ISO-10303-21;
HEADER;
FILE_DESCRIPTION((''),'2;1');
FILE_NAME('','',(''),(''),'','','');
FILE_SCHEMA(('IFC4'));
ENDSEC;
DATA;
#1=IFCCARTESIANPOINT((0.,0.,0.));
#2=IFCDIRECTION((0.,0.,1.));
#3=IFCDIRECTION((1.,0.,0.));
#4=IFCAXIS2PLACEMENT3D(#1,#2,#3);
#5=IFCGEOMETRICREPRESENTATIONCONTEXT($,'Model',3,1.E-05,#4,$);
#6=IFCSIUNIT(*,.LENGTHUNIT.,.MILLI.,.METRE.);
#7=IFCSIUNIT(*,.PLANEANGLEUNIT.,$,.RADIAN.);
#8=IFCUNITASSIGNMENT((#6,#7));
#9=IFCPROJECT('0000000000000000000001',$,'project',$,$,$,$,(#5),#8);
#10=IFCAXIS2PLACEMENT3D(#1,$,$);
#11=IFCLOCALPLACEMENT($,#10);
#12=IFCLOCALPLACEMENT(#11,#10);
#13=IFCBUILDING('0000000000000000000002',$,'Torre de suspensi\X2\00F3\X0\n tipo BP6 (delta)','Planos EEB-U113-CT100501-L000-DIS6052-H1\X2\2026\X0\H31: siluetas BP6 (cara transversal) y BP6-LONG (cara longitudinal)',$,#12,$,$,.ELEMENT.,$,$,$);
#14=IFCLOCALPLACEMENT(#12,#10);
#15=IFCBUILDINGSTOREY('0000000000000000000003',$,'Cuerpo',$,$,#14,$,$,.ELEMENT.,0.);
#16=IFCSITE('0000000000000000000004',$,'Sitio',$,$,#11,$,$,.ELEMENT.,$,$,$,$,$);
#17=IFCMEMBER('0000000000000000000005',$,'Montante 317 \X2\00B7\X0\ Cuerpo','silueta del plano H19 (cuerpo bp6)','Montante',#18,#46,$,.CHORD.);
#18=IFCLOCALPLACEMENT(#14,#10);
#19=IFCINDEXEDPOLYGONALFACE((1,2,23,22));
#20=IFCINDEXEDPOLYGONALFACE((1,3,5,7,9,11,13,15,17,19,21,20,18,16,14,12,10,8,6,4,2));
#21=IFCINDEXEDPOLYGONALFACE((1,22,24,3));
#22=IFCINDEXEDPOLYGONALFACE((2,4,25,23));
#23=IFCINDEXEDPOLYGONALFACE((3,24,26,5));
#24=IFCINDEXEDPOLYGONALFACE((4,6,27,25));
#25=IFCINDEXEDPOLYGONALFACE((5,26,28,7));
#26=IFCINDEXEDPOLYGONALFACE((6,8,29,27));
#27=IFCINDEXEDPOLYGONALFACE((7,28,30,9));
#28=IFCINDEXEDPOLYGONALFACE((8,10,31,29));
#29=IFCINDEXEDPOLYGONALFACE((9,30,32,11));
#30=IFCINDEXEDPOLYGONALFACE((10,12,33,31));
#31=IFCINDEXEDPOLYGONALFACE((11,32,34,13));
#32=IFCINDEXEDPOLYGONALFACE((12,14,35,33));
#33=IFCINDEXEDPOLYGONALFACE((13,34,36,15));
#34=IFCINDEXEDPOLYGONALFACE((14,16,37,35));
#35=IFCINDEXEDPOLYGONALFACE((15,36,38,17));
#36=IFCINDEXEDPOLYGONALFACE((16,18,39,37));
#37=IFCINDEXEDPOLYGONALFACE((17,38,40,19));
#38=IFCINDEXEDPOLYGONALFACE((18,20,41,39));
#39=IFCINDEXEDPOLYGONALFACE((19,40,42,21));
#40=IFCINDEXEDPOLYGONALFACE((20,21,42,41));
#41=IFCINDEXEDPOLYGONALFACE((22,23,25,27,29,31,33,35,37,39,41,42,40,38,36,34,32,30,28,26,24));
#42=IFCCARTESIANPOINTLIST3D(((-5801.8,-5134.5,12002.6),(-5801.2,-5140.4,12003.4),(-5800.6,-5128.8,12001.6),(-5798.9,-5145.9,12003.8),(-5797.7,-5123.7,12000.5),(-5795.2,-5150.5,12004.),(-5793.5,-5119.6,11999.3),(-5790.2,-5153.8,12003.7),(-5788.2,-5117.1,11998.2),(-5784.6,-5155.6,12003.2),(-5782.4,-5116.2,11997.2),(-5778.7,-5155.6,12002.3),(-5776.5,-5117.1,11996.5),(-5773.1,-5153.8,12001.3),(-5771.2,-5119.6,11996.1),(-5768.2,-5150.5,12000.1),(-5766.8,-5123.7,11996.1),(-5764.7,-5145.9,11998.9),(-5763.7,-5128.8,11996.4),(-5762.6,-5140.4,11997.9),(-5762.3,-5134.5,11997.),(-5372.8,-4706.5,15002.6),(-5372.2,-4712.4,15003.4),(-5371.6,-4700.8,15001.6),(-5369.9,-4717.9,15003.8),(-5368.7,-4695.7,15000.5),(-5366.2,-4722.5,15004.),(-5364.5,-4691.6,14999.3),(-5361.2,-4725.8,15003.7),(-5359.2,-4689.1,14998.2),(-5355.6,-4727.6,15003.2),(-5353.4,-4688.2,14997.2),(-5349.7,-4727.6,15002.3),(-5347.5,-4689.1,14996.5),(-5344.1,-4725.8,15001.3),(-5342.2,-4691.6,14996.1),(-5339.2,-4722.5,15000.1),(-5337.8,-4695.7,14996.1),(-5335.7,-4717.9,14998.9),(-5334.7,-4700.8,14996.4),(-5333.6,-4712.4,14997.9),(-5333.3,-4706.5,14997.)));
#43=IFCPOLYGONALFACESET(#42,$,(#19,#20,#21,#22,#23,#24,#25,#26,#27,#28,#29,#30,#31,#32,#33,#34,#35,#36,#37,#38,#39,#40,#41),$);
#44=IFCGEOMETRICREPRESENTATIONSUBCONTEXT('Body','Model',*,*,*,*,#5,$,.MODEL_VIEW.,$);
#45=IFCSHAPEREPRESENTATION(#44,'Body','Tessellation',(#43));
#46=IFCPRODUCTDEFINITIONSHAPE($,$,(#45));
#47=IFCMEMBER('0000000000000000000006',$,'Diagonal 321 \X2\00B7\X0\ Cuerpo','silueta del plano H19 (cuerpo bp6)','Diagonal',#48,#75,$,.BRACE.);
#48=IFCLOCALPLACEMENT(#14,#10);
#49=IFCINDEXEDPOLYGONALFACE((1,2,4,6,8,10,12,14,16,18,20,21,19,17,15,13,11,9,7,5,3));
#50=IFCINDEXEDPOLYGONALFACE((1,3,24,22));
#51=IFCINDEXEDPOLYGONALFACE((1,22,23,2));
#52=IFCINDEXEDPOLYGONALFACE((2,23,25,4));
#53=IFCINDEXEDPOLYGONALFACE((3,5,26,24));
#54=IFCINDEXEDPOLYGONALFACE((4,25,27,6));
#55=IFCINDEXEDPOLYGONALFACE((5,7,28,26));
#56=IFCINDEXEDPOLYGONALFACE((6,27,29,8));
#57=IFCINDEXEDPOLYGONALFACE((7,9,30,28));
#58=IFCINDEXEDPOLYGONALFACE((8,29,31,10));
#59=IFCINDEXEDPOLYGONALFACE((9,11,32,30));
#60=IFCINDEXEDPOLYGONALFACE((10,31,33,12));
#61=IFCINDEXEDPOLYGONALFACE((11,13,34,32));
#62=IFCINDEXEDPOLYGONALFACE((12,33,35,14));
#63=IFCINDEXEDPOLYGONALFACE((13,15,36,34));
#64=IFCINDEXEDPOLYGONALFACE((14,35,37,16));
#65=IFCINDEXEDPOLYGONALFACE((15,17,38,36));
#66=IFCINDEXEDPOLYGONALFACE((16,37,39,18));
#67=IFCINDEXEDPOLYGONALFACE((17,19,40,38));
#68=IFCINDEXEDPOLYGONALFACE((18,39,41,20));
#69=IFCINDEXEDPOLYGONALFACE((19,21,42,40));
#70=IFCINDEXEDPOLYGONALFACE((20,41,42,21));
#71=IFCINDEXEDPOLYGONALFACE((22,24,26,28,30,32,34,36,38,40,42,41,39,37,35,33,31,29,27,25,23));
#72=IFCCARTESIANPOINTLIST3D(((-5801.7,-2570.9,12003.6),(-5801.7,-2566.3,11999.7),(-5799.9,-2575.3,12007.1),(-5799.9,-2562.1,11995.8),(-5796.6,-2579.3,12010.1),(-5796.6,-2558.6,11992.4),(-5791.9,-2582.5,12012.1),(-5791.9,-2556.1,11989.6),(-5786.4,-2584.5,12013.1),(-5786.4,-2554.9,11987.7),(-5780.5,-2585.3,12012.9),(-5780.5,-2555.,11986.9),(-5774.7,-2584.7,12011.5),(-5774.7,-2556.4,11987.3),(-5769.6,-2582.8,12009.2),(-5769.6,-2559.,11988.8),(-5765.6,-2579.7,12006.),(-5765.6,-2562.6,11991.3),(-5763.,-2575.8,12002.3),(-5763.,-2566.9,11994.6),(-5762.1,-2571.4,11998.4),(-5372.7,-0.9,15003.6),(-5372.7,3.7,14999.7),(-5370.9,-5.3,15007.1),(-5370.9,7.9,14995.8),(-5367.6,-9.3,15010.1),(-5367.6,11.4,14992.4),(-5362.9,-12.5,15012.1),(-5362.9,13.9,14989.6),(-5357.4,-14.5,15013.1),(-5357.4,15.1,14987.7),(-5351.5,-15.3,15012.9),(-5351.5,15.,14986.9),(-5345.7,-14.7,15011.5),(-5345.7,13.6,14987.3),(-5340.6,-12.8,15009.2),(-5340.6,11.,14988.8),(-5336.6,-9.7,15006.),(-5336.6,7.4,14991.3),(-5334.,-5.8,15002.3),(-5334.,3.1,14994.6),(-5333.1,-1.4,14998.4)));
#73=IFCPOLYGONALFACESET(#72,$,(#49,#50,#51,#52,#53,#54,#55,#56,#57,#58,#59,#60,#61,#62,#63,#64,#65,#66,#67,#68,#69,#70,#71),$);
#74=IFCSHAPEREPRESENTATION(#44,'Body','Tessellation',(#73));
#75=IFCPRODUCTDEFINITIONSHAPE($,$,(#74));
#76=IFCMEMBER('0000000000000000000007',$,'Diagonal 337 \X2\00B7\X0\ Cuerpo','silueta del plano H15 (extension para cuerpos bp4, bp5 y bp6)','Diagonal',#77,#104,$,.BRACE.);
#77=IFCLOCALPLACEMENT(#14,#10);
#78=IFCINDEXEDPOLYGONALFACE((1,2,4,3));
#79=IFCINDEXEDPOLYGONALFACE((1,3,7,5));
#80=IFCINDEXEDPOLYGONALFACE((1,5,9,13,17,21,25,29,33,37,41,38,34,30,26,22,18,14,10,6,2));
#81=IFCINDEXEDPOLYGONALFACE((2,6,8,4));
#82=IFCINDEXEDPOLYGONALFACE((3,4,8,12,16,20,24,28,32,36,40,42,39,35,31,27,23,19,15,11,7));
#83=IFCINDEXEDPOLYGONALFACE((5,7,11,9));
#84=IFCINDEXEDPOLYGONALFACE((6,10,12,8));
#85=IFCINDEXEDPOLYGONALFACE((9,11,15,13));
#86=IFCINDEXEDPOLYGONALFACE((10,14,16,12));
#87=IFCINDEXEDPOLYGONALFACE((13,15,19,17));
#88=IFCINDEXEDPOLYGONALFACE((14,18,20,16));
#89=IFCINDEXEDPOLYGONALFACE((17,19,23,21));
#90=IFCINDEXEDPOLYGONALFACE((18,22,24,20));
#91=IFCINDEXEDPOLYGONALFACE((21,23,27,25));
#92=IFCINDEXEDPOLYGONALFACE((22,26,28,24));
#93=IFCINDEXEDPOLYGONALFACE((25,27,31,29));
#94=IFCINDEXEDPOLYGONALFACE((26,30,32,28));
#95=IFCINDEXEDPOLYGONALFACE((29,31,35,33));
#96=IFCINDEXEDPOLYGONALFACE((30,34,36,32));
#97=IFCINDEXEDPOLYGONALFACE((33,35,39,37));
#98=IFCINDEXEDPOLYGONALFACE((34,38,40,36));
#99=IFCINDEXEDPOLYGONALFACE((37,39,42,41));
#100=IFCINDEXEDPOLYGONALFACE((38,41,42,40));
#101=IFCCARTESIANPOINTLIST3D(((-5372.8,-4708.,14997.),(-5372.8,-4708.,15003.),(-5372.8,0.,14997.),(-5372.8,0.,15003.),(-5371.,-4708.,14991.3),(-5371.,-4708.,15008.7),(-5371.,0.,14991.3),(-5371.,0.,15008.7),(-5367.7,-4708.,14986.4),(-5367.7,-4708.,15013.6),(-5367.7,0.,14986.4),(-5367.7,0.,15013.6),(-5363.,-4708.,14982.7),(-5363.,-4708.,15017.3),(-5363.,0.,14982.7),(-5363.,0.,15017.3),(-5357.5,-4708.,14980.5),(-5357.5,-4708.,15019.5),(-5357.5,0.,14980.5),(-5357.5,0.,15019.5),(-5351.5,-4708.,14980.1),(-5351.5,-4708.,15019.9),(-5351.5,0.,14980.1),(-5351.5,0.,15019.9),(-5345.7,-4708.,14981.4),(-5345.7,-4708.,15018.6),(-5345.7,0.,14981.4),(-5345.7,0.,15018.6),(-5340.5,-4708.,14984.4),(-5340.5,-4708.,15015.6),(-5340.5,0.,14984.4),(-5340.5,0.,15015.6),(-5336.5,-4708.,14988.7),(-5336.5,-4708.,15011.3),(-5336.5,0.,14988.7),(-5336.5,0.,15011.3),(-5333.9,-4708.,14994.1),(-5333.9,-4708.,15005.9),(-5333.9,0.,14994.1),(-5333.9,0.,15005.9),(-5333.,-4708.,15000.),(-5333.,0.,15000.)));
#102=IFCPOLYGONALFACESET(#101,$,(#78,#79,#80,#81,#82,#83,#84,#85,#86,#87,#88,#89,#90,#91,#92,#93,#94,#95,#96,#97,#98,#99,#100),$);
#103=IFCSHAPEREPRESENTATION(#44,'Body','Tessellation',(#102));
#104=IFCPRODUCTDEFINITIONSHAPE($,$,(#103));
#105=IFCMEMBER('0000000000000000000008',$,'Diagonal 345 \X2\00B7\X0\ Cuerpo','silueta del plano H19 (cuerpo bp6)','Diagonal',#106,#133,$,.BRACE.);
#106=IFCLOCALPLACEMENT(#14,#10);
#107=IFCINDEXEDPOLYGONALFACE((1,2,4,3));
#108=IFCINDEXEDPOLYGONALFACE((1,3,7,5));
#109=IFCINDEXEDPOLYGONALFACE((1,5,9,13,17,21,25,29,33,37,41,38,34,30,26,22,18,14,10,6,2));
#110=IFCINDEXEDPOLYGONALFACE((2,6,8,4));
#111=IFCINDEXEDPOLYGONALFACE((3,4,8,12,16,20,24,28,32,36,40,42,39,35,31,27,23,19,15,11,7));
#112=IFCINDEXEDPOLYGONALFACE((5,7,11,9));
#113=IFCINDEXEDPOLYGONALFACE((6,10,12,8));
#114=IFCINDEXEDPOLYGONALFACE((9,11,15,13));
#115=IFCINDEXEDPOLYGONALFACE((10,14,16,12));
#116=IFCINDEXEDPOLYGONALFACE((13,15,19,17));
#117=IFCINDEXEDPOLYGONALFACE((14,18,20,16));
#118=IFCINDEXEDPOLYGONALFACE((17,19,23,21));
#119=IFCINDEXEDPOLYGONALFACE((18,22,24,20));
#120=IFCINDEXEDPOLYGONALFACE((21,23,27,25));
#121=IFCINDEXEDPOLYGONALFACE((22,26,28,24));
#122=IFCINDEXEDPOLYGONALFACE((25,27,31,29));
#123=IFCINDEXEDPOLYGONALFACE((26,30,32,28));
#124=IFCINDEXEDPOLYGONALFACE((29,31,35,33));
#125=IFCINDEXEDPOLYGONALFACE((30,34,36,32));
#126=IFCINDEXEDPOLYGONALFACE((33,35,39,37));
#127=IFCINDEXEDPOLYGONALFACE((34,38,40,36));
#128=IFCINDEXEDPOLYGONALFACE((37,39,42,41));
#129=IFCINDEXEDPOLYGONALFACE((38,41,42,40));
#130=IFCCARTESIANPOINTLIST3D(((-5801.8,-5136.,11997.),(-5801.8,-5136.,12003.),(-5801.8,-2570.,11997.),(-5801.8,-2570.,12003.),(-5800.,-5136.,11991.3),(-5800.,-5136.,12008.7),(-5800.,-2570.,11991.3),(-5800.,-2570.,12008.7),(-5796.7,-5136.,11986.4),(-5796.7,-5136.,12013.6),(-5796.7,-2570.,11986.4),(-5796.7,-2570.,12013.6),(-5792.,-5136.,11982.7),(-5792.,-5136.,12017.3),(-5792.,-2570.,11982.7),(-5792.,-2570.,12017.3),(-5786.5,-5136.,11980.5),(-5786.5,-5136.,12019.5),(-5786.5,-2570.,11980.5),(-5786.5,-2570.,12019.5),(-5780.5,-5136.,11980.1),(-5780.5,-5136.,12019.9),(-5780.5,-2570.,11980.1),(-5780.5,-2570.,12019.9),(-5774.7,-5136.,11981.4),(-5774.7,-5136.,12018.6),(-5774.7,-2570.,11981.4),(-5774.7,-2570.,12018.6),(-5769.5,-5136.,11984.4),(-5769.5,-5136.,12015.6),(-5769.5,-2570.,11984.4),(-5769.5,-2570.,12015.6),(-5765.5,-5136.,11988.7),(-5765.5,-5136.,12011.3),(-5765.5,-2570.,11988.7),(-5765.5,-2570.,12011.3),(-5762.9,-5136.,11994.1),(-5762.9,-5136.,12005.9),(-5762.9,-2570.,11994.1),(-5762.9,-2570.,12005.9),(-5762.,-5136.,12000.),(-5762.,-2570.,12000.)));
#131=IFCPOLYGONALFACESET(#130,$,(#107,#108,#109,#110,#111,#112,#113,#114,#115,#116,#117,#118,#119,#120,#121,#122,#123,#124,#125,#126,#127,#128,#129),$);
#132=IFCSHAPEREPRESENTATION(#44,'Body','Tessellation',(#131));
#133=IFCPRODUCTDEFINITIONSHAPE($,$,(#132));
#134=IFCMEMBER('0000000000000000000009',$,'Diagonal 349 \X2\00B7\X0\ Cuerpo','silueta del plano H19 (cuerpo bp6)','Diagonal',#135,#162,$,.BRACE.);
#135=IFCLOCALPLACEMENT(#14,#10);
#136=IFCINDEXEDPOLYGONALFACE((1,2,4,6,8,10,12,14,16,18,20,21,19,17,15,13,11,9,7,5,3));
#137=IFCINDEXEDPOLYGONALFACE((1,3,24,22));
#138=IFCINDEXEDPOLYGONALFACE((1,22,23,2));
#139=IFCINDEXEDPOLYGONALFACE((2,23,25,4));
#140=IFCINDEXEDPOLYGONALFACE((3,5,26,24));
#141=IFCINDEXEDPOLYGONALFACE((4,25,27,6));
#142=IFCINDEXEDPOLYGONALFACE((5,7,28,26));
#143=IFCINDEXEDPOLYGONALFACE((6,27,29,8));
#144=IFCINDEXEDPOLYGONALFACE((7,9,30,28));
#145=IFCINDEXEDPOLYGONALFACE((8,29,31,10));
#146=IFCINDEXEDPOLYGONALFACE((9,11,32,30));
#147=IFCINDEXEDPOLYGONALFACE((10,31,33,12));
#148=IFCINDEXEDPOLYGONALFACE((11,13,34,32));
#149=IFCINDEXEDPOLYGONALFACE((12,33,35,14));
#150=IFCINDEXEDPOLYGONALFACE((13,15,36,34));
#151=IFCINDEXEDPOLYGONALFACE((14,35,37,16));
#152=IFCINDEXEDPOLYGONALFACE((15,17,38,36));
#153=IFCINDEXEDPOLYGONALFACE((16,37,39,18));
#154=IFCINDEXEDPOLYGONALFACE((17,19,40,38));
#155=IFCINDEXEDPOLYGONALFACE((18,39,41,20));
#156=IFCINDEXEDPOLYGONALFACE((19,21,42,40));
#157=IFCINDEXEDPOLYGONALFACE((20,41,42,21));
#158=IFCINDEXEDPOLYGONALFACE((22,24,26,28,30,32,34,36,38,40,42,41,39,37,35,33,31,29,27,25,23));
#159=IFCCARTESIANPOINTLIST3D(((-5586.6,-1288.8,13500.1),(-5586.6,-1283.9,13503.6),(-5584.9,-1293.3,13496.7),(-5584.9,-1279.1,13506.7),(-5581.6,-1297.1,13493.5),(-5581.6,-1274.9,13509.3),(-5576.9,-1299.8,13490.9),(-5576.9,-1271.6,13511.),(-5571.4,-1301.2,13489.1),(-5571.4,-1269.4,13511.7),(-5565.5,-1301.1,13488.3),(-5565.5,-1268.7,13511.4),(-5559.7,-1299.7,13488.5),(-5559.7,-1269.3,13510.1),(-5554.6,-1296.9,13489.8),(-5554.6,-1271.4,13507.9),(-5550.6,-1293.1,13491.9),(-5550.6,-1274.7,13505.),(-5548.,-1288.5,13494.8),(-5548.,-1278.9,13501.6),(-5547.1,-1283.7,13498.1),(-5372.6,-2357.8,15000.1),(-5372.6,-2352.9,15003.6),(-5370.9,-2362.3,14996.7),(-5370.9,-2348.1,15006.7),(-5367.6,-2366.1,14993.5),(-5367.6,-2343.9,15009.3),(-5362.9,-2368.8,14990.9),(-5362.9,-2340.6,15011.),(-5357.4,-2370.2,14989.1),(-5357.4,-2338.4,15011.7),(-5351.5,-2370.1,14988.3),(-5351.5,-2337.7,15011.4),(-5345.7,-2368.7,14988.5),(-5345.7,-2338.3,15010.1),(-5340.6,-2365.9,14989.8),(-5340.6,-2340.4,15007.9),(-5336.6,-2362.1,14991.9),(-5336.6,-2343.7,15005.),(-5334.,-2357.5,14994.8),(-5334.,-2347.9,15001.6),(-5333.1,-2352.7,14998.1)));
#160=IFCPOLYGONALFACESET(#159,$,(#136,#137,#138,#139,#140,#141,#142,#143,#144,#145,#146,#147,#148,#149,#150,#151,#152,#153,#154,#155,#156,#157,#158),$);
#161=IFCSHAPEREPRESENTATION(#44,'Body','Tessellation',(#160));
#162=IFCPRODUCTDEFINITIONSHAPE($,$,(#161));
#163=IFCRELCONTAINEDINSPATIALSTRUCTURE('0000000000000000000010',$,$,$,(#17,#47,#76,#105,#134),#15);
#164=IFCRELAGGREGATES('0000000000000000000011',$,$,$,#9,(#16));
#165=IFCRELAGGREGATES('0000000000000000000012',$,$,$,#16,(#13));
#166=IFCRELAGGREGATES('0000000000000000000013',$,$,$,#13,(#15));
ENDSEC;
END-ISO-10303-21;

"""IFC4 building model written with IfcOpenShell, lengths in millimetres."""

from ifc_helpers import new_model, si_unit, frame, origin, origin_with_axes, place, context, subcontext, project, spatial, circle, extrude, element, save


model = new_model("IFC4")

# Units and contexts
model_context = context("Model", 3, precision=1e-05, world=origin_with_axes())
body_context = subcontext(model_context, "Body", "Model", "MODEL_VIEW")
ifc_project = project(units=[si_unit("LENGTHUNIT", "METRE", prefix="MILLI"), si_unit("PLANEANGLEUNIT", "RADIAN")], contexts=[model_context])

# Site, building, storey
site_placement = place(None, origin())
site = spatial("IfcSite", under=ifc_project, at=site_placement, Name="Sitio", CompositionType="ELEMENT")
building_placement = place(site_placement, origin())
building = spatial("IfcBuilding", under=site, at=building_placement, Name="Torre de suspensión tipo BP6 (delta)", Description="Planos EEB-U113-CT100501-L000-DIS6052-H1…H31: siluetas BP6 (cara transversal) y BP6-LONG (cara longitudinal)", CompositionType="ELEMENT")
storey_placement = place(building_placement, origin())
storey = spatial("IfcBuildingStorey", under=building, at=storey_placement, Name="Cuerpo", CompositionType="ELEMENT", Elevation=0.0)

# Members
member_1_placement = place(storey_placement, frame((-5353.0, -4708.0, 15000.0), z_axis=(-0.140169, -0.139842, -0.980202), x_axis=(-0.019796, 0.990174, -0.138434)))
element("IfcMember", 1, at=member_1_placement, inside=storey, Name="Montante 317 · Cuerpo", Description="silueta del plano H19 (cuerpo bp6)", ObjectType="Montante", PredefinedType="CHORD", context=body_context, shape_type="SweptSolid", body=[
    extrude(circle(Radius=20.0), None, (0.0, 0.0, 1.0), 3060.6),
])
member_2_placement = place(storey_placement, frame((-5353.0, 0.0, 15000.0), z_axis=(-0.107964, -0.64678, -0.754996), x_axis=(0.994155, -0.07024, -0.081992)))
element("IfcMember", 2, at=member_2_placement, inside=storey, Name="Diagonal 321 · Cuerpo", Description="silueta del plano H19 (cuerpo bp6)", ObjectType="Diagonal", PredefinedType="BRACE", context=body_context, shape_type="SweptSolid", body=[
    extrude(circle(Radius=20.0), None, (0.0, 0.0, 1.0), 3973.5),
])
member_3_placement = place(storey_placement, frame((-5353.0, -4708.0, 15000.0), z_axis=(0.0, 1.0, 0.0), x_axis=(1.0, 0.0, 0.0)))
element("IfcMember", 3, at=member_3_placement, inside=storey, Name="Diagonal 337 · Cuerpo", Description="silueta del plano H15 (extension para cuerpos bp4, bp5 y bp6)", ObjectType="Diagonal", PredefinedType="BRACE", context=body_context, shape_type="SweptSolid", body=[
    extrude(circle(Radius=20.0), None, (0.0, 0.0, 1.0), 4708.0),
])
member_4_placement = place(storey_placement, frame((-5782.0, -5136.0, 12000.0), z_axis=(0.0, 1.0, 0.0), x_axis=(1.0, 0.0, 0.0)))
element("IfcMember", 4, at=member_4_placement, inside=storey, Name="Diagonal 345 · Cuerpo", Description="silueta del plano H19 (cuerpo bp6)", ObjectType="Diagonal", PredefinedType="BRACE", context=body_context, shape_type="SweptSolid", body=[
    extrude(circle(Radius=20.0), None, (0.0, 0.0, 1.0), 2566.0),
])
member_5_placement = place(storey_placement, frame((-5353.0, -2354.0, 15000.0), z_axis=(-0.115405, 0.576487, -0.808915), x_axis=(0.993318, 0.066977, -0.093981)))
element("IfcMember", 5, at=member_5_placement, inside=storey, Name="Diagonal 349 · Cuerpo", Description="silueta del plano H19 (cuerpo bp6)", ObjectType="Diagonal", PredefinedType="BRACE", context=body_context, shape_type="SweptSolid", body=[
    extrude(circle(Radius=20.0), None, (0.0, 0.0, 1.0), 1854.3),
])

save(model, "model.ifc")
